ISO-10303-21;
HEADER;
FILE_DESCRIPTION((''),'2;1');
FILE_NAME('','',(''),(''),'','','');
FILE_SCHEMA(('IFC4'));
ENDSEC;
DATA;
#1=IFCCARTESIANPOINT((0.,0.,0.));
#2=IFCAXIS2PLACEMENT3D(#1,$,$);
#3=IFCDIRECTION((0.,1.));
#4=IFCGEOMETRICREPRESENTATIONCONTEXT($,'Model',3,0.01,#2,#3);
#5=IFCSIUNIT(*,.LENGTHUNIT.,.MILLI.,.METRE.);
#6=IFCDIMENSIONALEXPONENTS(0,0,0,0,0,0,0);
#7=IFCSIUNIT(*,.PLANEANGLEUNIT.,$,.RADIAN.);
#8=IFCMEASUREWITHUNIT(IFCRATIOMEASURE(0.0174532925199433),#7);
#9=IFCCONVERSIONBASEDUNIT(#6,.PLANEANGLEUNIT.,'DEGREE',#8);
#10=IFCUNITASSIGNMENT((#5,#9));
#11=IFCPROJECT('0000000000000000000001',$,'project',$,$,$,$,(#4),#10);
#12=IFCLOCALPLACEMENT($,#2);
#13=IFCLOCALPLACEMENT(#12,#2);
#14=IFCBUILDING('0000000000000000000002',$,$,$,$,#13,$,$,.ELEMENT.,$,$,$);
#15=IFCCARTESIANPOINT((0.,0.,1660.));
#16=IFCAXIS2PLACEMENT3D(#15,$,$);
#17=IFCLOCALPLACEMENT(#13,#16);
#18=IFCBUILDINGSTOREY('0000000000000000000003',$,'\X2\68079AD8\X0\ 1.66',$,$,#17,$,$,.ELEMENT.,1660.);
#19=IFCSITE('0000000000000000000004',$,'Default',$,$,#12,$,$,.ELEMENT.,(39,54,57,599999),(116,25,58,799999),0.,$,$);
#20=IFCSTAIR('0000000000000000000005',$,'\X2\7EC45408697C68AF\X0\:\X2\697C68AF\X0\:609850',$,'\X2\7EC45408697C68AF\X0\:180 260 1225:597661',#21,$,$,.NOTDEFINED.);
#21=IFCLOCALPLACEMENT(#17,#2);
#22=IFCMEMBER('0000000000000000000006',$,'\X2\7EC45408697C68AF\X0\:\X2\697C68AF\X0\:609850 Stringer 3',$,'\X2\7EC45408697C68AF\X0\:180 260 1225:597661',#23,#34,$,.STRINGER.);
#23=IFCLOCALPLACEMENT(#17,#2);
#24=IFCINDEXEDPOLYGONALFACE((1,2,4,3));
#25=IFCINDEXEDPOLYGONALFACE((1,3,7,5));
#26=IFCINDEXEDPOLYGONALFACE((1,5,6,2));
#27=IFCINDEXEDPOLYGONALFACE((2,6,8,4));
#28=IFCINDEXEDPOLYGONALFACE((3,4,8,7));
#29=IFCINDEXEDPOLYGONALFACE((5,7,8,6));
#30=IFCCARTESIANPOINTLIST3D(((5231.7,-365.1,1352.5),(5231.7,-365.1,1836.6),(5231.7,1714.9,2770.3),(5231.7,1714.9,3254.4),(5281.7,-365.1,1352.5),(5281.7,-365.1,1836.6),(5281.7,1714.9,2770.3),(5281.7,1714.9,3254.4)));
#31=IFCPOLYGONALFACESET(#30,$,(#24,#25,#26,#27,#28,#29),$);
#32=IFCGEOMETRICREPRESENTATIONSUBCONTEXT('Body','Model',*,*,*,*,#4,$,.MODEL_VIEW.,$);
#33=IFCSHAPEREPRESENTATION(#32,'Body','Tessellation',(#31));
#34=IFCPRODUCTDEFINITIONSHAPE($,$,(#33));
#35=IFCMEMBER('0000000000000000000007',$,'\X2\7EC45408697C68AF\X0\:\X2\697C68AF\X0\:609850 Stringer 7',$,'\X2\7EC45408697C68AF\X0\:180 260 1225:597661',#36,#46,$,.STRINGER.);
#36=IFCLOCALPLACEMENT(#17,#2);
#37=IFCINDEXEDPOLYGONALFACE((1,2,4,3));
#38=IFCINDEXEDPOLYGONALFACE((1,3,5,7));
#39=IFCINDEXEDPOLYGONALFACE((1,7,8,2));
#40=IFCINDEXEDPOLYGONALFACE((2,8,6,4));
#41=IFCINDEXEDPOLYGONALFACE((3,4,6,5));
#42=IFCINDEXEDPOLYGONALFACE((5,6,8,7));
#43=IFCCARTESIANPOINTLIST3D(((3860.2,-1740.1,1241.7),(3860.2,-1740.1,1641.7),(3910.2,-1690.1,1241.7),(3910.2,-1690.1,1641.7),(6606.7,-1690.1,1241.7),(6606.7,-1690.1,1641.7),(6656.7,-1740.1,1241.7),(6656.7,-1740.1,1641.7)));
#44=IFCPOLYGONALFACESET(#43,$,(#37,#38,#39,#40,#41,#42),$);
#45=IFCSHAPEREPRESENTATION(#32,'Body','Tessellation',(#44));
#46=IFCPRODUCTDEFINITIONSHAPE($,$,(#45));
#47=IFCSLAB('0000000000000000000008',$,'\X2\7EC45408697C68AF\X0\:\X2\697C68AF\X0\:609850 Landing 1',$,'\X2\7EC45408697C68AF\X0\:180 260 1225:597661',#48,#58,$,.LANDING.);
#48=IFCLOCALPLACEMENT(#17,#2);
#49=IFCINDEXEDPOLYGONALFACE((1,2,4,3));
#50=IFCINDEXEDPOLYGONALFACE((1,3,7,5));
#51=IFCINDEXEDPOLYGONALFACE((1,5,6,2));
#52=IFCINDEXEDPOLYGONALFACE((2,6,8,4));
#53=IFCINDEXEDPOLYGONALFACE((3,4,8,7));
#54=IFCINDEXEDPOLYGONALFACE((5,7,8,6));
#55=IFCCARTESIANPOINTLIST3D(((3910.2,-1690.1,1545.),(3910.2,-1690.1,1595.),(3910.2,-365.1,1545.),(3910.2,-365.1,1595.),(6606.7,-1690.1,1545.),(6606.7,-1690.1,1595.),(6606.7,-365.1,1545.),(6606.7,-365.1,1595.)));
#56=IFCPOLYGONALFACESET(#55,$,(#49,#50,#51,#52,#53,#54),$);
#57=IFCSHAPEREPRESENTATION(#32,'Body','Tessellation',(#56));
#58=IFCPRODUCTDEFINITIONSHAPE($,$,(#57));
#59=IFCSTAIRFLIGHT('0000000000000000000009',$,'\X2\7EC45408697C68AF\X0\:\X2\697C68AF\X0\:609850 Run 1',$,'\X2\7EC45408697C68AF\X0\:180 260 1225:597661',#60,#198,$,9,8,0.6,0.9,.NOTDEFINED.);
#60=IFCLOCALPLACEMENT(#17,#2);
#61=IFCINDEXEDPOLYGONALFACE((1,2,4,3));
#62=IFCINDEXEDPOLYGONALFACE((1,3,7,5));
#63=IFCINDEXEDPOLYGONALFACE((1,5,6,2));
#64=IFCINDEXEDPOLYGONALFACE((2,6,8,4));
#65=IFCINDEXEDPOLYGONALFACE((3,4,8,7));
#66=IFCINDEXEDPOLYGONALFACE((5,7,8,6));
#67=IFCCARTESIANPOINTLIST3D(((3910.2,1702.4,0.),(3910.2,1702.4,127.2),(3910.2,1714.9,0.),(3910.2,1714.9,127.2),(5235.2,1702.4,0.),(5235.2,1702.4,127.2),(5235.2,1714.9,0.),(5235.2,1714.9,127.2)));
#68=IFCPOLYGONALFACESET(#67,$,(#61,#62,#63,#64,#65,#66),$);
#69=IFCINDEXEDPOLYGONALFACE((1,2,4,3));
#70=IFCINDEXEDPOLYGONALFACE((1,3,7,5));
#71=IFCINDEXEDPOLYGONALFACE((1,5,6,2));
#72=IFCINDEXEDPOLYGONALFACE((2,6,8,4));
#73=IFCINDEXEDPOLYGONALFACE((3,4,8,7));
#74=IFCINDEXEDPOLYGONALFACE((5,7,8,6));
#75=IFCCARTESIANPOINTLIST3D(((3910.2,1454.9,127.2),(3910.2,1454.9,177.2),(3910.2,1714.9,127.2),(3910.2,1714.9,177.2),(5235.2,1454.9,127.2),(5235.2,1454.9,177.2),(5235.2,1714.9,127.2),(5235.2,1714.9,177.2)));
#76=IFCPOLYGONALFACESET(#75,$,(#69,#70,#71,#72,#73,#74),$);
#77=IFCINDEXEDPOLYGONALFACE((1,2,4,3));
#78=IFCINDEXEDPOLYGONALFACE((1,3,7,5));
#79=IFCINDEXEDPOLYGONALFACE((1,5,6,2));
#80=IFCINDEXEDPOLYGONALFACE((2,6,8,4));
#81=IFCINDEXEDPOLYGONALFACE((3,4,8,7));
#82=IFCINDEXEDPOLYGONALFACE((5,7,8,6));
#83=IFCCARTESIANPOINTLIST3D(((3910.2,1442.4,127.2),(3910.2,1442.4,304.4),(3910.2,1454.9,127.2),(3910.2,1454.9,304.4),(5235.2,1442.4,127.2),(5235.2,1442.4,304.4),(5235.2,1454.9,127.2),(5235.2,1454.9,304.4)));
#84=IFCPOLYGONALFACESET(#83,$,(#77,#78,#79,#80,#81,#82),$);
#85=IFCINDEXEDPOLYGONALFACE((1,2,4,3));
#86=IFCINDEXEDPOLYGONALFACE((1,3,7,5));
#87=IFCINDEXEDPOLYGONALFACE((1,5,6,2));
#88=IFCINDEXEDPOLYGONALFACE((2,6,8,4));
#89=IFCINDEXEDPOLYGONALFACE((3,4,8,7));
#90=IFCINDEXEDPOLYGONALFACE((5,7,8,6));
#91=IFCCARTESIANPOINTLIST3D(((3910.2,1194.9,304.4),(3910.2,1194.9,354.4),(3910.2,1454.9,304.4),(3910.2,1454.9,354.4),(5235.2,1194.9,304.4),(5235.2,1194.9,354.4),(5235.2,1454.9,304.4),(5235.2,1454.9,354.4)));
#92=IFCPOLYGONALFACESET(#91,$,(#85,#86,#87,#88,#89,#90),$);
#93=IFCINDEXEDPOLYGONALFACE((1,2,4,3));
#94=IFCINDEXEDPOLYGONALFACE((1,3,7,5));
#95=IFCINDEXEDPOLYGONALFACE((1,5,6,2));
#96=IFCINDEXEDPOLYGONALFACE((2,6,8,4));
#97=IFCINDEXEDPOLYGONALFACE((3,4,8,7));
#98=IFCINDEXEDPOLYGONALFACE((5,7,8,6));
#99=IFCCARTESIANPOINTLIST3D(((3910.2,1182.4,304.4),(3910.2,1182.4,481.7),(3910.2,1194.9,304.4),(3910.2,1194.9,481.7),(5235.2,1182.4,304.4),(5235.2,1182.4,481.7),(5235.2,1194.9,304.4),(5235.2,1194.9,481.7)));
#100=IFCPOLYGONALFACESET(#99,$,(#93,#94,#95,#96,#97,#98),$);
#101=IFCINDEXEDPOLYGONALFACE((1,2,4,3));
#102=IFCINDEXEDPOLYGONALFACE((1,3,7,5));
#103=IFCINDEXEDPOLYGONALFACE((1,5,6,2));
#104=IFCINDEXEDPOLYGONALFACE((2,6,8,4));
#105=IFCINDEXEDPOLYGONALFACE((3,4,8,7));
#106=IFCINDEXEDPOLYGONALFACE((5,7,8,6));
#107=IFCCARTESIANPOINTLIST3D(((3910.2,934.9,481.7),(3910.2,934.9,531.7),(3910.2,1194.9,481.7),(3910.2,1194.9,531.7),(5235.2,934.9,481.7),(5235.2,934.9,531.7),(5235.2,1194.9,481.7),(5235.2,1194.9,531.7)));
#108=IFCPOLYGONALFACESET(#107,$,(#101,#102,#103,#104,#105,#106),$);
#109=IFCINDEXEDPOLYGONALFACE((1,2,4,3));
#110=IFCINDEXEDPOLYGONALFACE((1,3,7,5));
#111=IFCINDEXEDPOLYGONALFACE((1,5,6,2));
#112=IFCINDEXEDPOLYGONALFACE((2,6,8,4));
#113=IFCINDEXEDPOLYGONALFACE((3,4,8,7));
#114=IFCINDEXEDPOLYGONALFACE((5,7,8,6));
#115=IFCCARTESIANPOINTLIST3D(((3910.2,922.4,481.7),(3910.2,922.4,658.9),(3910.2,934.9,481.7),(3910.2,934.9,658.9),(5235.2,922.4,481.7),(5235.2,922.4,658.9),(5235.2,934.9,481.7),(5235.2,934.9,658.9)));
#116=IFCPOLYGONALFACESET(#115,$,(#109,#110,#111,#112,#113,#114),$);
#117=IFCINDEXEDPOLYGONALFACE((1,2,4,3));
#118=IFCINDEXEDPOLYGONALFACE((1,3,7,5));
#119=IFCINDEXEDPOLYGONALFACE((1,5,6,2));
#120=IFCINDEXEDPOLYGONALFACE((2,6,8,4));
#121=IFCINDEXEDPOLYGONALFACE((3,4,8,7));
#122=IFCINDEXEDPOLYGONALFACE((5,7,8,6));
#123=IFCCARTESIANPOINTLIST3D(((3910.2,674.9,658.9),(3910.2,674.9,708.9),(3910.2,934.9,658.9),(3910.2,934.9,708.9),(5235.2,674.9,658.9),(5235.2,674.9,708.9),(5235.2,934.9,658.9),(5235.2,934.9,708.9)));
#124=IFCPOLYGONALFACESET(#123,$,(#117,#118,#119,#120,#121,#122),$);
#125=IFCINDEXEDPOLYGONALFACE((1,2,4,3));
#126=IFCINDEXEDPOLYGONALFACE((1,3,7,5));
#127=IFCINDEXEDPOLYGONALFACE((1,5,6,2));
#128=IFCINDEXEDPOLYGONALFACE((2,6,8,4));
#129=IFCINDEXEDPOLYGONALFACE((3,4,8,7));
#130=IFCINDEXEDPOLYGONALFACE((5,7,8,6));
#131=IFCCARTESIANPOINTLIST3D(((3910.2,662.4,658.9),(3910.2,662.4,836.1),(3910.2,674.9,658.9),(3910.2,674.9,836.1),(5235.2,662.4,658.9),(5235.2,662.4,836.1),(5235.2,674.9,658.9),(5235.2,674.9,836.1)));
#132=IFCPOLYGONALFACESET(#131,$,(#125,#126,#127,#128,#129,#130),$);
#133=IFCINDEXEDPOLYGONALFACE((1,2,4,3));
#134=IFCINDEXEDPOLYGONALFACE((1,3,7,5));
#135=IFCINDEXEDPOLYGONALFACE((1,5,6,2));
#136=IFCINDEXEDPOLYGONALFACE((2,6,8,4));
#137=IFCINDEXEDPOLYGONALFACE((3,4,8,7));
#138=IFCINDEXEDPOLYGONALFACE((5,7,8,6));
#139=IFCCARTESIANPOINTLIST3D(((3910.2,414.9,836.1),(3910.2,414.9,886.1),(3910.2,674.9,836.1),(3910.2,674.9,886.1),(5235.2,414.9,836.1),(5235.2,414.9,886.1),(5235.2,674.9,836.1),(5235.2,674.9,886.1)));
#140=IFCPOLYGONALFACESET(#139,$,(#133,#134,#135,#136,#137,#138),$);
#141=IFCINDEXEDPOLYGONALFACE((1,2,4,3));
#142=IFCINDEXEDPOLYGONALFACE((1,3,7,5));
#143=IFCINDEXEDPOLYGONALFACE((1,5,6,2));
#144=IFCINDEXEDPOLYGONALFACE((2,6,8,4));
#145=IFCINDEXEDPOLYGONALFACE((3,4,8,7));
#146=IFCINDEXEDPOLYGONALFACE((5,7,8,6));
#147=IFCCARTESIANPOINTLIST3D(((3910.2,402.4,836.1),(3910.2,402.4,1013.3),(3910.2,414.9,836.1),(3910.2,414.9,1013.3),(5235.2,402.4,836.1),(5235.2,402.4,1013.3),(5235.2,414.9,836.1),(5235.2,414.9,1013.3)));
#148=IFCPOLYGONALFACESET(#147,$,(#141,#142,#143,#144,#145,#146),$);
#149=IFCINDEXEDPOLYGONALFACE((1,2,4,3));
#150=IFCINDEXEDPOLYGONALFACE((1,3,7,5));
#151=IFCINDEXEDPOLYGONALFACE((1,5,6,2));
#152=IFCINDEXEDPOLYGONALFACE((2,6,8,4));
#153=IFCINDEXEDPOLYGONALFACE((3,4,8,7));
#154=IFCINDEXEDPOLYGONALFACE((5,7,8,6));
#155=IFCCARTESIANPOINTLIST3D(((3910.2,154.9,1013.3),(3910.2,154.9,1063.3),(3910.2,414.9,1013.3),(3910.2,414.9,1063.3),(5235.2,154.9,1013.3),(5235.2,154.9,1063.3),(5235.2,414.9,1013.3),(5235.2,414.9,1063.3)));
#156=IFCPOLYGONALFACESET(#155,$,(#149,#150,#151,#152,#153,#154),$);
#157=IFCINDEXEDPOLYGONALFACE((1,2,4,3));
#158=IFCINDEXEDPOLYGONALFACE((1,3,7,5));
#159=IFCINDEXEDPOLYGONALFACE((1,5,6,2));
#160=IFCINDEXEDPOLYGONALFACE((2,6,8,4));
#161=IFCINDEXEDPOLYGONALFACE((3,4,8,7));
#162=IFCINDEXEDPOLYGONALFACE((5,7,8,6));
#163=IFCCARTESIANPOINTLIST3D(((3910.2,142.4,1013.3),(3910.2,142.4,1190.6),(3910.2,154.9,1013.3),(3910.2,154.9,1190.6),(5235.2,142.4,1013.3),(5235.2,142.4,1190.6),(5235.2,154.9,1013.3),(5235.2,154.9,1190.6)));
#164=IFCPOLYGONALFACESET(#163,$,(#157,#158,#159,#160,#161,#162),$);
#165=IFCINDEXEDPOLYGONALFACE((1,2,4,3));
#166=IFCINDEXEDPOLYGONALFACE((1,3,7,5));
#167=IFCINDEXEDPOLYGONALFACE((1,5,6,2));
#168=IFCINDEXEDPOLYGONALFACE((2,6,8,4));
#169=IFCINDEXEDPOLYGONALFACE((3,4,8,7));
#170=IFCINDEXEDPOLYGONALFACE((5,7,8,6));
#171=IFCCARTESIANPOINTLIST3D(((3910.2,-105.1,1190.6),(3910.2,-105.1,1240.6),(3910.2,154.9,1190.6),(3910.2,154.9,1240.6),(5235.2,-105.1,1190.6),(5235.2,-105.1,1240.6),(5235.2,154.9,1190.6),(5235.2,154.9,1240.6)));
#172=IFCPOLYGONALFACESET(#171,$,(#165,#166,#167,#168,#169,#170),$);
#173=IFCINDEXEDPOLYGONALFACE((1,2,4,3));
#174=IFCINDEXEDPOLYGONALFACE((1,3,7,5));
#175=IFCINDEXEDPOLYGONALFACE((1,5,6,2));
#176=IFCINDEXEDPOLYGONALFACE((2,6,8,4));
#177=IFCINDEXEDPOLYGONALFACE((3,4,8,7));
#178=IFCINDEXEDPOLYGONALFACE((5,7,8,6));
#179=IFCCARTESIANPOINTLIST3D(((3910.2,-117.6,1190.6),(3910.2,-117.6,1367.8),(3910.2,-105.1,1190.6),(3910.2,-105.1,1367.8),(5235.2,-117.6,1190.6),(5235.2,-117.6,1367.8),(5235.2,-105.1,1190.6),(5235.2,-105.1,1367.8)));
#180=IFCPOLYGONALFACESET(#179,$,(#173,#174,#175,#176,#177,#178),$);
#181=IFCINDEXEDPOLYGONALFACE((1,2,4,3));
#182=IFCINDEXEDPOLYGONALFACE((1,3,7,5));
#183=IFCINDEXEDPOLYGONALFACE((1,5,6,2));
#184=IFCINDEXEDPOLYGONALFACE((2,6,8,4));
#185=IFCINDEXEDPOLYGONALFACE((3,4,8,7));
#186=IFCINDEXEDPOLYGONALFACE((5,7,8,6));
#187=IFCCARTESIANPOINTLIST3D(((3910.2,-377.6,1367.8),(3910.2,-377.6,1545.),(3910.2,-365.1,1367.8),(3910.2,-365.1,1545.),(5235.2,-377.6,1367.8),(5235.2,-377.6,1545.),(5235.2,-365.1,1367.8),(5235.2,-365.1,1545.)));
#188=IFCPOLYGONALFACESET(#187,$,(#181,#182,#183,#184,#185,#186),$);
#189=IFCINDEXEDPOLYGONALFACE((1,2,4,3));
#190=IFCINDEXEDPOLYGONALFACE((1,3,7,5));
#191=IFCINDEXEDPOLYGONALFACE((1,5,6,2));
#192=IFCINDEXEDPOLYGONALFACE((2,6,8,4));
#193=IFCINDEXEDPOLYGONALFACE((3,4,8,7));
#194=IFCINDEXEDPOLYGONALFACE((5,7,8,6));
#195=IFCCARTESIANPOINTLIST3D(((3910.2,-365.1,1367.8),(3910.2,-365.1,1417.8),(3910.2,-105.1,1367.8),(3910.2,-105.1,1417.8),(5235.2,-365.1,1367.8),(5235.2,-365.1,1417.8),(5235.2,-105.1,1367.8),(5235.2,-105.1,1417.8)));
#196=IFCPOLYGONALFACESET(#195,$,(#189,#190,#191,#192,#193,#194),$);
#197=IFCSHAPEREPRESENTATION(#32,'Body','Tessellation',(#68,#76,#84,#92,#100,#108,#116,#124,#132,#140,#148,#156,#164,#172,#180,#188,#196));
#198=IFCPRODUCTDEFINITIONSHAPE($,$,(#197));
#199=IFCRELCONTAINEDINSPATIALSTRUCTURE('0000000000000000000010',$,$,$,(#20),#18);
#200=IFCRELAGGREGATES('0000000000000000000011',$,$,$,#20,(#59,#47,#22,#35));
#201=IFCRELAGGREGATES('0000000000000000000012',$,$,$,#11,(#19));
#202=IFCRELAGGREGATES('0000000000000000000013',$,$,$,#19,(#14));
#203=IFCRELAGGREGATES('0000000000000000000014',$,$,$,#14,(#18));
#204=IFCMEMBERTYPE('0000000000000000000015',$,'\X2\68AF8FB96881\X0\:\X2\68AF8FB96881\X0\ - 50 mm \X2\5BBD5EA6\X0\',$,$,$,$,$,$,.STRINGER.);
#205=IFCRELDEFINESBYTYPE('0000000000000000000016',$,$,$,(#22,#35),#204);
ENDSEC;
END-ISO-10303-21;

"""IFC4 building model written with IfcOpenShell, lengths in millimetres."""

from ifc_helpers import new_model, entity, si_unit, converted_unit, direction, frame, frame_2d, origin, origin_2d_with_axis, place, context, subcontext, project, spatial, polyline, rectangle, outline, extrude, type_object, element, aggregate, save


model = new_model("IFC4")

# Units and contexts
model_context = context("Model", 3, precision=0.01, world=origin(), true_north=direction((0.0, 1.0)))
body_context = subcontext(model_context, "Body", "Model", "MODEL_VIEW")
ifc_project = project(units=[si_unit("LENGTHUNIT", "METRE", prefix="MILLI"), converted_unit("PLANEANGLEUNIT", "DEGREE", entity("IfcRatioMeasure", 0.0174532925199433), si_unit("PLANEANGLEUNIT", "RADIAN"), dimensions=[0, 0, 0, 0, 0, 0, 0])], contexts=[model_context])

# Site, building, storey
site_placement = place(None, origin())
site = spatial("IfcSite", under=ifc_project, at=site_placement, Name="Default", CompositionType="ELEMENT", RefLatitude=(39, 54, 57, 599999), RefLongitude=(116, 25, 58, 799999), RefElevation=0.0)
building_placement = place(site_placement, origin())
building = spatial("IfcBuilding", under=site, at=building_placement, CompositionType="ELEMENT")
storey_placement = place(building_placement, frame((0.0, 0.0, 1660.0)))
storey = spatial("IfcBuildingStorey", under=building, at=storey_placement, Name="标高 1.66", CompositionType="ELEMENT", Elevation=1660.0)

# Stair, members, slab, stair flight
stair_placement = place(storey_placement, origin())
stair = element("IfcStair", 1, at=stair_placement, inside=storey, Name="组合楼梯:楼梯:609850", ObjectType="组合楼梯:180 260 1225:597661", PredefinedType="NOTDEFINED")
member_type = type_object("IfcMemberType", Name="梯边梁:梯边梁 - 50 mm 宽度", PredefinedType="STRINGER")
member_1_placement = place(stair_placement, frame((5231.7, -365.1, 1352.5)))
member_1 = element("IfcMember", 2, at=member_1_placement, type_object=member_type, Name="组合楼梯:楼梯:609850 Stringer 3", ObjectType="组合楼梯:180 260 1225:597661", PredefinedType="STRINGER", context=body_context, shape_type="SweptSolid", body=[
    extrude(outline(polyline([(-1394.9, -200.0), (1122.3, -200.0), (1394.9, 200.0), (-1122.3, 200.0), (-1394.9, -200.0)])), frame((0.0, 1040.0, 950.9), z_axis=(1.0, 0.0, 0.0), x_axis=(0.0, 0.826302, 0.563227)), (0.0, 0.0, 1.0), 50.0),
])
member_2_placement = place(stair_placement, frame((3860.2, -1740.1, 1241.7)))
member_2 = element("IfcMember", 3, at=member_2_placement, type_object=member_type, Name="组合楼梯:楼梯:609850 Stringer 7", ObjectType="组合楼梯:180 260 1225:597661", PredefinedType="STRINGER", context=body_context, shape_type="SweptSolid", body=[
    extrude(outline(polyline([(-1398.3, -25.0), (1398.3, -25.0), (1348.3, 25.0), (-1348.3, 25.0), (-1398.3, -25.0)])), frame((1398.3, 25.0, 0.0)), (0.0, 0.0, 1.0), 400.0),
])
slab_placement = place(stair_placement, frame((3910.2, -1690.1, 0.0)))
slab = element("IfcSlab", 4, at=slab_placement, Name="组合楼梯:楼梯:609850 Landing 1", ObjectType="组合楼梯:180 260 1225:597661", PredefinedType="LANDING", context=body_context, shape_type="SweptSolid", body=[
    extrude(rectangle(XDim=2696.6, YDim=1325.0, at=frame_2d((0.0, 220.8), x_axis=(1.0, 0.0))), frame((1348.3, 883.3, 1545.0), z_axis=(0.0, 0.0, 1.0), x_axis=(-1.0, 0.0, 0.0)), (0.0, 0.0, 1.0), 50.0),
])
stair_flight_1_placement = place(stair_placement, frame((3910.2, -377.6, 0.0)))
stair_flight_1 = element("IfcStairFlight", 5, at=stair_flight_1_placement, Name="组合楼梯:楼梯:609850 Run 1", ObjectType="组合楼梯:180 260 1225:597661", NumberOfRisers=9, NumberOfTreads=8, PredefinedType="NOTDEFINED", RiserHeight=0.6, TreadLength=0.9, context=body_context, shape_type="SweptSolid", body=[
    extrude(rectangle(XDim=1325.0, YDim=12.5, at=frame_2d((0.0, 0.0), x_axis=(1.0, 0.0))), frame((662.5, 2086.2, 0.0)), (0.0, 0.0, 1.0), 127.2),
    extrude(rectangle(XDim=260.0, YDim=1325.0, at=frame_2d((0.0, 0.0), x_axis=(1.0, 0.0))), frame((662.5, 1962.5, 127.2), z_axis=(0.0, 0.0, 1.0), x_axis=(0.0, 1.0, 0.0)), (0.0, 0.0, 1.0), 50.0),
    extrude(rectangle(XDim=1325.0, YDim=12.5, at=frame_2d((0.0, 0.0), x_axis=(1.0, 0.0))), frame((662.5, 1826.2, 127.2)), (0.0, 0.0, 1.0), 177.2),
    extrude(rectangle(XDim=260.0, YDim=1325.0, at=frame_2d((0.0, 0.0), x_axis=(1.0, 0.0))), frame((662.5, 1702.5, 304.4), z_axis=(0.0, 0.0, 1.0), x_axis=(0.0, 1.0, 0.0)), (0.0, 0.0, 1.0), 50.0),
    extrude(rectangle(XDim=1325.0, YDim=12.5, at=frame_2d((0.0, 0.0), x_axis=(1.0, 0.0))), frame((662.5, 1566.2, 304.4)), (0.0, 0.0, 1.0), 177.2),
    extrude(rectangle(XDim=260.0, YDim=1325.0, at=frame_2d((0.0, 0.0), x_axis=(1.0, 0.0))), frame((662.5, 1442.5, 481.7), z_axis=(0.0, 0.0, 1.0), x_axis=(0.0, 1.0, 0.0)), (0.0, 0.0, 1.0), 50.0),
    extrude(rectangle(XDim=1325.0, YDim=12.5, at=frame_2d((0.0, 0.0), x_axis=(1.0, 0.0))), frame((662.5, 1306.2, 481.7)), (0.0, 0.0, 1.0), 177.2),
    extrude(rectangle(XDim=260.0, YDim=1325.0, at=frame_2d((0.0, 0.0), x_axis=(1.0, 0.0))), frame((662.5, 1182.5, 658.9), z_axis=(0.0, 0.0, 1.0), x_axis=(0.0, 1.0, 0.0)), (0.0, 0.0, 1.0), 50.0),
    extrude(rectangle(XDim=1325.0, YDim=12.5, at=frame_2d((0.0, 0.0), x_axis=(1.0, 0.0))), frame((662.5, 1046.2, 658.9)), (0.0, 0.0, 1.0), 177.2),
    extrude(rectangle(XDim=260.0, YDim=1325.0, at=frame_2d((0.0, 0.0), x_axis=(1.0, 0.0))), frame((662.5, 922.5, 836.1), z_axis=(0.0, 0.0, 1.0), x_axis=(0.0, 1.0, 0.0)), (0.0, 0.0, 1.0), 50.0),
    extrude(rectangle(XDim=1325.0, YDim=12.5, at=frame_2d((0.0, 0.0), x_axis=(1.0, 0.0))), frame((662.5, 786.3, 836.1)), (0.0, 0.0, 1.0), 177.2),
    extrude(rectangle(XDim=260.0, YDim=1325.0, at=frame_2d((0.0, 0.0), x_axis=(1.0, 0.0))), frame((662.5, 662.5, 1013.3), z_axis=(0.0, 0.0, 1.0), x_axis=(0.0, 1.0, 0.0)), (0.0, 0.0, 1.0), 50.0),
    extrude(rectangle(XDim=1325.0, YDim=12.5, at=frame_2d((0.0, 0.0), x_axis=(1.0, 0.0))), frame((662.5, 526.2, 1013.3)), (0.0, 0.0, 1.0), 177.2),
    extrude(rectangle(XDim=260.0, YDim=1325.0, at=frame_2d((0.0, 0.0), x_axis=(1.0, 0.0))), frame((662.5, 402.5, 1190.6), z_axis=(0.0, 0.0, 1.0), x_axis=(0.0, 1.0, 0.0)), (0.0, 0.0, 1.0), 50.0),
    extrude(rectangle(XDim=1325.0, YDim=12.5, at=frame_2d((0.0, 0.0), x_axis=(1.0, 0.0))), frame((662.5, 266.3, 1190.6)), (0.0, 0.0, 1.0), 177.2),
    extrude(rectangle(XDim=1325.0, YDim=12.5, at=origin_2d_with_axis()), frame((662.5, 6.2, 1367.8)), (0.0, 0.0, 1.0), 177.2),
    extrude(rectangle(XDim=260.0, YDim=1325.0, at=frame_2d((0.0, 0.0), x_axis=(1.0, 0.0))), frame((662.5, 142.5, 1367.8), z_axis=(0.0, 0.0, 1.0), x_axis=(0.0, 1.0, 0.0)), (0.0, 0.0, 1.0), 50.0),
])
aggregate(stair, [stair_flight_1, slab, member_1, member_2])

save(model, "model.ifc")
